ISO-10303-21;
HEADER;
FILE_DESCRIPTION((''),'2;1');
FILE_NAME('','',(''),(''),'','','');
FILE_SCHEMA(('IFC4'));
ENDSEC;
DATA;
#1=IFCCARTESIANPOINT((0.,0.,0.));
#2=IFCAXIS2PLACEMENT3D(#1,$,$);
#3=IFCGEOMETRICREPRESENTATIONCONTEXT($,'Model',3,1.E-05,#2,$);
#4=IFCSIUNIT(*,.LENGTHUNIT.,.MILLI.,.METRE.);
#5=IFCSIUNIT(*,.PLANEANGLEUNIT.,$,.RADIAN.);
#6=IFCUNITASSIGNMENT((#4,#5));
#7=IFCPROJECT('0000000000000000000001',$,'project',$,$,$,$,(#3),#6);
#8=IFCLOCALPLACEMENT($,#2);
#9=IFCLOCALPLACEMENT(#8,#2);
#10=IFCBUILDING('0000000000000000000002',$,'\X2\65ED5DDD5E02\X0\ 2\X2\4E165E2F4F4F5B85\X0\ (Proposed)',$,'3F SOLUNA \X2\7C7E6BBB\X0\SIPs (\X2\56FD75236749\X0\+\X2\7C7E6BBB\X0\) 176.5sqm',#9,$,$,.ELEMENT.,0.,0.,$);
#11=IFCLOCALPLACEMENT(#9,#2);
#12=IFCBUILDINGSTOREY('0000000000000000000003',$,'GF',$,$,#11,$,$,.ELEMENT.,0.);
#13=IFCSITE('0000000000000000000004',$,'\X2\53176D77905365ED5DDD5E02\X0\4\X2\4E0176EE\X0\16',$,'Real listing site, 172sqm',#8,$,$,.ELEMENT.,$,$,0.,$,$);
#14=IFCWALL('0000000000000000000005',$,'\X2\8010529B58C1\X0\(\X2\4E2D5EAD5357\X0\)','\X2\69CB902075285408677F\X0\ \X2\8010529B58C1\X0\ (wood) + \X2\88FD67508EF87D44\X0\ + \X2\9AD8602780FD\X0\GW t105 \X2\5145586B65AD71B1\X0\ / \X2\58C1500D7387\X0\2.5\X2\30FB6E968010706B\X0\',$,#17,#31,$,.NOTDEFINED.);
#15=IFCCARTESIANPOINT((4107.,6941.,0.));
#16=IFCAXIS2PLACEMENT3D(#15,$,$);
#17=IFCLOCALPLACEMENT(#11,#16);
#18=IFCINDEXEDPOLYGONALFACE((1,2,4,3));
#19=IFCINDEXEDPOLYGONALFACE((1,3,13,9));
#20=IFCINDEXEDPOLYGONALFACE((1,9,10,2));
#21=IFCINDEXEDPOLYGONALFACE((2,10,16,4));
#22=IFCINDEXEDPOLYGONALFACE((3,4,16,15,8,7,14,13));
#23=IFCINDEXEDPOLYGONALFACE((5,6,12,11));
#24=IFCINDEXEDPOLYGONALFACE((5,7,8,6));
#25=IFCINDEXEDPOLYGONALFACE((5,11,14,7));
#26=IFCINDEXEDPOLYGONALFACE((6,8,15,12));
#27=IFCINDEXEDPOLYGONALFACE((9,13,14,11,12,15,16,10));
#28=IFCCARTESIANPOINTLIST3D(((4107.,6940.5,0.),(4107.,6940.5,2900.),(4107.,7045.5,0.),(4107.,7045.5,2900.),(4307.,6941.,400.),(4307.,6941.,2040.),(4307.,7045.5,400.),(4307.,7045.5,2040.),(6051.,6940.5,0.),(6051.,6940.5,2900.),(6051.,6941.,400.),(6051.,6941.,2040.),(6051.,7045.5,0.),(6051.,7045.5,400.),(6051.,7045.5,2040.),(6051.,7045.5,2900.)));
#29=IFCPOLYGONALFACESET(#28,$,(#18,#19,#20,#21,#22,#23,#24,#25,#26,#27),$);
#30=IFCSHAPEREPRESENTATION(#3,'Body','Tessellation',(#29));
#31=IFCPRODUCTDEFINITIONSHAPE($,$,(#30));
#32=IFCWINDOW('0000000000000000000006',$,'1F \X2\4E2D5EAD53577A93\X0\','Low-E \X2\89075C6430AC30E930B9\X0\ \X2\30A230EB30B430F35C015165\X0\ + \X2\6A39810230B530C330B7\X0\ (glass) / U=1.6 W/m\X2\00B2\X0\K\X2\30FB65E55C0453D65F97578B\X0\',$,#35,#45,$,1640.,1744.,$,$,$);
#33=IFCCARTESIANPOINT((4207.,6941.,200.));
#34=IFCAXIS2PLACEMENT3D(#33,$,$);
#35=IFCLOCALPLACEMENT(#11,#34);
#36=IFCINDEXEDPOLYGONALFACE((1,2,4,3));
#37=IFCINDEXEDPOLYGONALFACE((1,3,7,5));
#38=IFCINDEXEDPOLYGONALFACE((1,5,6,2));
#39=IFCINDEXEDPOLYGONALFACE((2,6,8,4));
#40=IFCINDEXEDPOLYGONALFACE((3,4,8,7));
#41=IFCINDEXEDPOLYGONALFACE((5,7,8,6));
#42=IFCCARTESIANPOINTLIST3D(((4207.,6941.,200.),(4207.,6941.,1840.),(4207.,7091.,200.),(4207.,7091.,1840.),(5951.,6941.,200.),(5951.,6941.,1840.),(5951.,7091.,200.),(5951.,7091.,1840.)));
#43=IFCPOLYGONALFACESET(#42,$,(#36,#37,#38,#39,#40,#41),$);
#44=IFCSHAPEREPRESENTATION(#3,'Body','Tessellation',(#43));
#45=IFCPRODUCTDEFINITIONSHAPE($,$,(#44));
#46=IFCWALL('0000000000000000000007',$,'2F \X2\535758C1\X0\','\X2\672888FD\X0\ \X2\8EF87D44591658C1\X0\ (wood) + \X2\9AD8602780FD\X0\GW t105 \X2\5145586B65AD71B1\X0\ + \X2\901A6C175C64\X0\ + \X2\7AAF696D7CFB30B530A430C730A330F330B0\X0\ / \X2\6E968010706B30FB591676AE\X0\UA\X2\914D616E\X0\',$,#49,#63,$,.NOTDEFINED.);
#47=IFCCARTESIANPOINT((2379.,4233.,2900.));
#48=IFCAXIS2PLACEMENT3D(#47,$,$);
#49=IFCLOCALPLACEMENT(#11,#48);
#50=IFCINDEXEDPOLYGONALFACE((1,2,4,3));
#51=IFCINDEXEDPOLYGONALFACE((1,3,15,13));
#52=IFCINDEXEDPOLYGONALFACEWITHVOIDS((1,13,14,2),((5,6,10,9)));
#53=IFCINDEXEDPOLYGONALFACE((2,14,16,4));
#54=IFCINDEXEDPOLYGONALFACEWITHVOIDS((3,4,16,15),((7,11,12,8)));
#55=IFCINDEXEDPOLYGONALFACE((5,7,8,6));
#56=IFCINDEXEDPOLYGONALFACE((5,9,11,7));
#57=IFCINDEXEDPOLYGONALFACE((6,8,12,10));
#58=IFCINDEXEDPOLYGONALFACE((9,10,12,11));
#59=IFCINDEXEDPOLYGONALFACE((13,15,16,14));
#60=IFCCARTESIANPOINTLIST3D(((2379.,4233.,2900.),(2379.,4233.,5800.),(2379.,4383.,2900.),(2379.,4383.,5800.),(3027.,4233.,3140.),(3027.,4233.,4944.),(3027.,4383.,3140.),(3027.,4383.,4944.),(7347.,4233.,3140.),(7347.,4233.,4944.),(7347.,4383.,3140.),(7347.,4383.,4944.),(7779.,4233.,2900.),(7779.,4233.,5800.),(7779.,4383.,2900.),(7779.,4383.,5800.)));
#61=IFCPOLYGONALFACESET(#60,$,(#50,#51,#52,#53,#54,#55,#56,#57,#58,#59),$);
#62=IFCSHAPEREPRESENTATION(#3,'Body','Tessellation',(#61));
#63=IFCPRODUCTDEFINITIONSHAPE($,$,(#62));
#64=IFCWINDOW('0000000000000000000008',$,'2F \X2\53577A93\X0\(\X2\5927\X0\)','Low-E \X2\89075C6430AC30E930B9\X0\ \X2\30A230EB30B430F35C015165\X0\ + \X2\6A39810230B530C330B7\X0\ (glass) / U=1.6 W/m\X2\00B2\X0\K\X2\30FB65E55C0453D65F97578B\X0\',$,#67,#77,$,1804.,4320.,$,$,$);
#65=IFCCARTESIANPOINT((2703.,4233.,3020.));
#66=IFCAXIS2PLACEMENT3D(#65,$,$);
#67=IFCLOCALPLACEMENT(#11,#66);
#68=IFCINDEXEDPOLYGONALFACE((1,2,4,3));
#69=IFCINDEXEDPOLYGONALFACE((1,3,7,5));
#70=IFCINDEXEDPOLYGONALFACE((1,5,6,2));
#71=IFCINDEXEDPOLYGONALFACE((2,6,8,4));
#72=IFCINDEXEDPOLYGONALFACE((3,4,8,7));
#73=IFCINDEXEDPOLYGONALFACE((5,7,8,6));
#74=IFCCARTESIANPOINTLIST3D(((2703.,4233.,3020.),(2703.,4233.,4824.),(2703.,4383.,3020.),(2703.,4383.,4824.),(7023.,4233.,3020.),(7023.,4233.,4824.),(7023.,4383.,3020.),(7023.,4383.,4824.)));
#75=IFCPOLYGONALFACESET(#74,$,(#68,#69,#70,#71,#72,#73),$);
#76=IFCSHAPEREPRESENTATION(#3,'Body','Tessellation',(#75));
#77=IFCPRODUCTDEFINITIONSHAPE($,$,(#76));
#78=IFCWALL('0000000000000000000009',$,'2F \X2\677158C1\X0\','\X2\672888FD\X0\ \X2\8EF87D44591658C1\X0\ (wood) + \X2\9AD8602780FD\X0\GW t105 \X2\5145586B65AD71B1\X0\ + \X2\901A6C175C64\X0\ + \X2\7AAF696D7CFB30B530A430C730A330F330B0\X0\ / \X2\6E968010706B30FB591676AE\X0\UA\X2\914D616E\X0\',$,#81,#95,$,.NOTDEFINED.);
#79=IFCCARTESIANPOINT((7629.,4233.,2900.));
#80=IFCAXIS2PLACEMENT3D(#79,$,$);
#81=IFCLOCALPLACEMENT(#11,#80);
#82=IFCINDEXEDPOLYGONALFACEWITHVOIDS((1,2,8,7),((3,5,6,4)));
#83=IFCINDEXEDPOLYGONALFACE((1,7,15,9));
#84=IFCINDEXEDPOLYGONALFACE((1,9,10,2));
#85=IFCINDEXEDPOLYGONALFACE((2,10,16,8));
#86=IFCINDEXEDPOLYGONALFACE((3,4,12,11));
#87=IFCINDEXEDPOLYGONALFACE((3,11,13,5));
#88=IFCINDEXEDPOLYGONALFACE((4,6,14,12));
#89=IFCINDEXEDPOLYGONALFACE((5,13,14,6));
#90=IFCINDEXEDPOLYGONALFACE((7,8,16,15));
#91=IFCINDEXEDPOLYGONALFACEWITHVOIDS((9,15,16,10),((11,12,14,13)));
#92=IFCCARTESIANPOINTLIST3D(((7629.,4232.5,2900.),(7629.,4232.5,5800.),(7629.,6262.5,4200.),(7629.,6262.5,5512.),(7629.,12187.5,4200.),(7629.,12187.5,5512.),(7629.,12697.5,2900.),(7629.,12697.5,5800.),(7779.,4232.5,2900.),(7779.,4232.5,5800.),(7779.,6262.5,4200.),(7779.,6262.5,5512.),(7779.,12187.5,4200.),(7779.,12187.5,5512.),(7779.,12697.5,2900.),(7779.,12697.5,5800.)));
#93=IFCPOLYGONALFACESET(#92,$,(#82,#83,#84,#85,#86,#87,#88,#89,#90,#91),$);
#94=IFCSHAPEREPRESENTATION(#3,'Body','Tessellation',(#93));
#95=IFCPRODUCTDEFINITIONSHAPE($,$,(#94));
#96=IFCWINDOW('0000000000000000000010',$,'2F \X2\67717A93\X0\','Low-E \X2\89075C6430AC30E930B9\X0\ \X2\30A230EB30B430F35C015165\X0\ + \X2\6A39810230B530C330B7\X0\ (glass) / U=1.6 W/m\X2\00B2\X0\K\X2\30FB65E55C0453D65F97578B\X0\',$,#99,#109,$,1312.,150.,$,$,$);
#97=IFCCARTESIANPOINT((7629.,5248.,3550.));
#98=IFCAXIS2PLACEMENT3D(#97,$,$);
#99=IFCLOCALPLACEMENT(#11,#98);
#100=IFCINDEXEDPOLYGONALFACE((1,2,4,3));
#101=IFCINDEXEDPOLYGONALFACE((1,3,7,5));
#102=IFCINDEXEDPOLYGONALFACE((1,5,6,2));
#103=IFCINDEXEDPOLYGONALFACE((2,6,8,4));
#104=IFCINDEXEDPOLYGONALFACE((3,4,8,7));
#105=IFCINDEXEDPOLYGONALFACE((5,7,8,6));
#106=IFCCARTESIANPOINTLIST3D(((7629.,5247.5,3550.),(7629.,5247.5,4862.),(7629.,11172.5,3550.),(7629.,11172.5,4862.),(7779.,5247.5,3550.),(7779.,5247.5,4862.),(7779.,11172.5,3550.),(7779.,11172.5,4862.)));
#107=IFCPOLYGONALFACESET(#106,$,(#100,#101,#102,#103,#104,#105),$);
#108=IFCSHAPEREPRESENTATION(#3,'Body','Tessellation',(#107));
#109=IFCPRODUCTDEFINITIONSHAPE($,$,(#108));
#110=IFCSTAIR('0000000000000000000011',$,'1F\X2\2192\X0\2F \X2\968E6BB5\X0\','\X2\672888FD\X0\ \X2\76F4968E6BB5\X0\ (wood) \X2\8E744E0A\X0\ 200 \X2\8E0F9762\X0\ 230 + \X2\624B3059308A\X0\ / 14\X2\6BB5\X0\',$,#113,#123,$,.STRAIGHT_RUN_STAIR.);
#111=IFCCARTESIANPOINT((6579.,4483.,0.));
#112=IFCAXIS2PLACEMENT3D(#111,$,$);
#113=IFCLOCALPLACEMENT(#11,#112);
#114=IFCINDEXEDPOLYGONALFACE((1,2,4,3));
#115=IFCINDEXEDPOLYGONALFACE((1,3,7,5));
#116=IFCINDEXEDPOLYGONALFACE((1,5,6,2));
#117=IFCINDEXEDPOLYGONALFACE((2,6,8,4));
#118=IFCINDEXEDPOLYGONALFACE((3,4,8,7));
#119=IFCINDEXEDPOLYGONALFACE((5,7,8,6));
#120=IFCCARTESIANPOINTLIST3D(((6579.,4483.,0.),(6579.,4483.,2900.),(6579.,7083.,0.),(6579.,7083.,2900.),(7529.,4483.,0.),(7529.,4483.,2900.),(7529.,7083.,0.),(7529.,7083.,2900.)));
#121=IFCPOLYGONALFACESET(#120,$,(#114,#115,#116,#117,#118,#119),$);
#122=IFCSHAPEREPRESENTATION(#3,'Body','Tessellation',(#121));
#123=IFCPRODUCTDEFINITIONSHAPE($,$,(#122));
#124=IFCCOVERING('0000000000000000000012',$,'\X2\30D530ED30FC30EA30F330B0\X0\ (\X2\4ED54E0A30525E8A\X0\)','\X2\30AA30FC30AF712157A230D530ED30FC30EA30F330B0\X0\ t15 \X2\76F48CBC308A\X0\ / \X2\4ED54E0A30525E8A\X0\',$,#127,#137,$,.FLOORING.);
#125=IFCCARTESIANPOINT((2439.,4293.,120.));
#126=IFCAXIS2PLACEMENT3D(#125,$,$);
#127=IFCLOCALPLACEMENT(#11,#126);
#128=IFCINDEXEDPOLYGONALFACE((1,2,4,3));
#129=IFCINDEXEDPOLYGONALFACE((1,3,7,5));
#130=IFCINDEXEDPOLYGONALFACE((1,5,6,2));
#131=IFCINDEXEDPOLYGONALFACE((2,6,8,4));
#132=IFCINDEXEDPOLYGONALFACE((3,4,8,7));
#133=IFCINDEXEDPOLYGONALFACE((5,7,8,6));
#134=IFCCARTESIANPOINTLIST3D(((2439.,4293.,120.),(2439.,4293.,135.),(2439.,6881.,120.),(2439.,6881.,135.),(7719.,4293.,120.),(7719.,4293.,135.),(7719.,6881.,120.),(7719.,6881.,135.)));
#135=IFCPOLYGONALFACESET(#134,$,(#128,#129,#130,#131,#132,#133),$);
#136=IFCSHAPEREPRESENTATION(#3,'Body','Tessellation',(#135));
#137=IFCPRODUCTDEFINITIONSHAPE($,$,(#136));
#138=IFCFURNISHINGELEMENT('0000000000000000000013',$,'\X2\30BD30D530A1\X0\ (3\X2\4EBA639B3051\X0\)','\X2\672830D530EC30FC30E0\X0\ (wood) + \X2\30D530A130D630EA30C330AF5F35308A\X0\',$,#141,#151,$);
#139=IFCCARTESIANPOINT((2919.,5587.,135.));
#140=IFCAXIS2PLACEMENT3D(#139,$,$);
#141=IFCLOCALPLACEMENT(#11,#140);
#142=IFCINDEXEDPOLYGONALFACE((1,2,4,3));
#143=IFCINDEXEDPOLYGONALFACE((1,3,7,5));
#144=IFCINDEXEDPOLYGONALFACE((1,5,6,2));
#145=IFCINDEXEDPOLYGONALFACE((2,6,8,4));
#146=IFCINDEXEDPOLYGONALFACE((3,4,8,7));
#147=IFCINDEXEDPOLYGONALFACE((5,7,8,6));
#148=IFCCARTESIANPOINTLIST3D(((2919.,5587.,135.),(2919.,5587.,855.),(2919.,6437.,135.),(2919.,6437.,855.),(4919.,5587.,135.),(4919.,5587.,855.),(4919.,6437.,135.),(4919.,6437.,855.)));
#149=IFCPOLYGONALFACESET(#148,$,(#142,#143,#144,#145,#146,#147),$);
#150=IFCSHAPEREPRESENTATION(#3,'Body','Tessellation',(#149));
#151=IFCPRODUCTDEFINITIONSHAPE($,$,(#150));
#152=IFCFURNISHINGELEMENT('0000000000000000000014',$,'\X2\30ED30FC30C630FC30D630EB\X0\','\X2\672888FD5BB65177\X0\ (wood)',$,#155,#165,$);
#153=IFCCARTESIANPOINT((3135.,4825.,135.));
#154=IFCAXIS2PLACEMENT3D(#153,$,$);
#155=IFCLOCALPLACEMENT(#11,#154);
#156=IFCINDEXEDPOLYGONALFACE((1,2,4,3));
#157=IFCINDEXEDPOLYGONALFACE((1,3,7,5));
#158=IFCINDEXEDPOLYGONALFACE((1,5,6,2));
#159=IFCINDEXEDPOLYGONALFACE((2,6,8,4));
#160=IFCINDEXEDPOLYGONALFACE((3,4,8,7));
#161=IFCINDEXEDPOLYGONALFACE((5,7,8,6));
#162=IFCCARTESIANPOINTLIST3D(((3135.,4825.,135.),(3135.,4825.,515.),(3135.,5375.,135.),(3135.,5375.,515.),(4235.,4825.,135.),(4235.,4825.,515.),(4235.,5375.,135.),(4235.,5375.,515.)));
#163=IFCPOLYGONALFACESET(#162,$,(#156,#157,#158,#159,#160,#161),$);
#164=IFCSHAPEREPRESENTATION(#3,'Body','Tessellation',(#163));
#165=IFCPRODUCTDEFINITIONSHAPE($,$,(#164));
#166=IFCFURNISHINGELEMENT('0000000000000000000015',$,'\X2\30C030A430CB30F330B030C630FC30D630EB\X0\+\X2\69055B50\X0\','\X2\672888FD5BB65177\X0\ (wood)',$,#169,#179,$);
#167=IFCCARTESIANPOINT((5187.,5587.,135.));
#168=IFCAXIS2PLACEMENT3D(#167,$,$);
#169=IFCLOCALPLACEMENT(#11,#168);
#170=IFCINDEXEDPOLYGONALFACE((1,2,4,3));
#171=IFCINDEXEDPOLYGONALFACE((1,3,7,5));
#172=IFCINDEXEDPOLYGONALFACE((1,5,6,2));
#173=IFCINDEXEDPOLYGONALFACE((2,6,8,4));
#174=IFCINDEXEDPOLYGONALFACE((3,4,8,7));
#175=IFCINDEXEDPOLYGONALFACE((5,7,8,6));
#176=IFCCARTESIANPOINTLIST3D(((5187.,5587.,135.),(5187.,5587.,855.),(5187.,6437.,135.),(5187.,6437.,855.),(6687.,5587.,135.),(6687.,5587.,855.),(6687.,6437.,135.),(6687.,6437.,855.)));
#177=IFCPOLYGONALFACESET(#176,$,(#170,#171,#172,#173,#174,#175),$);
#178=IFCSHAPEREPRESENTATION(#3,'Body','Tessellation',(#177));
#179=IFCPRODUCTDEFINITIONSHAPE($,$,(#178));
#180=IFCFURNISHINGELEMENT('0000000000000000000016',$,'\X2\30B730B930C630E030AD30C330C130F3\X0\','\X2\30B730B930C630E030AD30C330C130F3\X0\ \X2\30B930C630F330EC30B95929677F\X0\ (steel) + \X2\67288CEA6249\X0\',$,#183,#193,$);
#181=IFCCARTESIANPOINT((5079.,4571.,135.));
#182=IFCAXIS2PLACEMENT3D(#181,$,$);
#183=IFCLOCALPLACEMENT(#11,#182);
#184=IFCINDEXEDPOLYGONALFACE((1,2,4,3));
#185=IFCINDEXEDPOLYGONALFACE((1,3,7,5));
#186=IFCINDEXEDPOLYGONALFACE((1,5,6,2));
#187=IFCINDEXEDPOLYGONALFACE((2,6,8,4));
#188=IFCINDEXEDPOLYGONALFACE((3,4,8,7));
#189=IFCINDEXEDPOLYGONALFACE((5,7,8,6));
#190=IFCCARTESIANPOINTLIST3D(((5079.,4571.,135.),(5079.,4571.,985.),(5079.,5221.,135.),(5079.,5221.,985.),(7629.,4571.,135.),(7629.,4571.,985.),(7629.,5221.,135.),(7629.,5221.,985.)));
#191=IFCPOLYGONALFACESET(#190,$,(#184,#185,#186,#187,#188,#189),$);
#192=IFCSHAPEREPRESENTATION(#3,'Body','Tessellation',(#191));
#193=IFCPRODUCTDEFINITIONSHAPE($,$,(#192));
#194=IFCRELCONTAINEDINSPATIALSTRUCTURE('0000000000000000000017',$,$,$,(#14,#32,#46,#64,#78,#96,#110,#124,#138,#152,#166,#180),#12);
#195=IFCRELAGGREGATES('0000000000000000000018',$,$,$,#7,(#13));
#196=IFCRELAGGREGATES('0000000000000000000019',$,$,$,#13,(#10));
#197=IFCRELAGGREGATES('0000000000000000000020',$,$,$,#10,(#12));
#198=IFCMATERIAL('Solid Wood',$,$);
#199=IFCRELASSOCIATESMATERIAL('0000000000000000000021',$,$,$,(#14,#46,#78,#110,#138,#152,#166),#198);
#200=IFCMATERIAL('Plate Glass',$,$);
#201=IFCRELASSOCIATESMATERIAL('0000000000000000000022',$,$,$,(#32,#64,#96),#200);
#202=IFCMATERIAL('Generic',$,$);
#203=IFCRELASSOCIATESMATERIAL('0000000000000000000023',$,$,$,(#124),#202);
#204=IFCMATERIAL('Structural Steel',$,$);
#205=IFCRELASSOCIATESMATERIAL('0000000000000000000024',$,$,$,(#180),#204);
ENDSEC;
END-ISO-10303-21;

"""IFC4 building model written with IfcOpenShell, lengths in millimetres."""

from ifc_helpers import new_model, si_unit, frame, frame_2d, origin, place, context, project, spatial, rectangle, extrude, material, element, fill, save


model = new_model("IFC4")

# Units and contexts
model_context = context("Model", 3, precision=1e-05, world=origin())
ifc_project = project(units=[si_unit("LENGTHUNIT", "METRE", prefix="MILLI"), si_unit("PLANEANGLEUNIT", "RADIAN")], contexts=[model_context])

# Site, building, storey
site_placement = place(None, origin())
site = spatial("IfcSite", under=ifc_project, at=site_placement, Name="北海道旭川市4丁目16", ObjectType="Real listing site, 172sqm", CompositionType="ELEMENT", RefElevation=0.0)
building_placement = place(site_placement, origin())
building = spatial("IfcBuilding", under=site, at=building_placement, Name="旭川市 2世帯住宅 (Proposed)", ObjectType="3F SOLUNA 籾殻SIPs (国産杉+籾殻) 176.5sqm", CompositionType="ELEMENT", ElevationOfRefHeight=0.0, ElevationOfTerrain=0.0)
storey_placement = place(building_placement, origin())
storey = spatial("IfcBuildingStorey", under=building, at=storey_placement, Name="GF", CompositionType="ELEMENT", Elevation=0.0)

# Shared definitions
ifc_material_1 = material(Name="Solid Wood")
ifc_material_2 = material(Name="Generic")

# Shared definitions
ifc_material_3 = material(Name="Plate Glass")

# Wall, opening, window
wall_1_placement = place(storey_placement, frame((4107.0, 6941.0, 0.0)))
wall_1 = element("IfcWall", 1, at=wall_1_placement, inside=storey, material=ifc_material_1, Name="耐力壁(中庭南)", Description="構造用合板 耐力壁 (wood) + 製材軸組 + 高性能GW t105 充填断熱 / 壁倍率2.5・準耐火", PredefinedType="NOTDEFINED", context=model_context, shape_type="SweptSolid", body=[
    extrude(rectangle(XDim=1944.0, YDim=105.0, at=frame_2d((972.0, 52.0))), frame((4107.0, 6941.0, 0.0)), (0.0, 0.0, 1.0), 2900.0),
])
opening_1_placement = place(storey_placement, frame((4207.0, 6941.0, 200.0)))
opening_1 = element("IfcOpeningElement", 2, at=opening_1_placement, cuts=wall_1, PredefinedType="NOTDEFINED", context=model_context, shape_type="SweptSolid", body=[
    extrude(rectangle(XDim=1744.0, YDim=150.0, at=frame_2d((872.0, 75.0))), frame((4207.0, 6941.0, 200.0)), (0.0, 0.0, 1.0), 1640.0),
])
window_1_placement = place(storey_placement, frame((4207.0, 6941.0, 200.0)))
window_1 = element("IfcWindow", 3, at=window_1_placement, inside=storey, material=ifc_material_3, Name="1F 中庭南窓", Description="Low-E 複層ガラス アルゴン封入 + 樹脂サッシ (glass) / U=1.6 W/m²K・日射取得型", OverallHeight=1640.0, OverallWidth=1744.0, context=model_context, shape_type="SweptSolid", body=[
    extrude(rectangle(XDim=1744.0, YDim=150.0, at=frame_2d((872.0, 75.0))), frame((4207.0, 6941.0, 200.0)), (0.0, 0.0, 1.0), 1640.0),
])
fill(opening_1, window_1)

# Walls, openings, windows
wall_2_placement = place(storey_placement, frame((2379.0, 4233.0, 2900.0)))
wall_2 = element("IfcWall", 4, at=wall_2_placement, inside=storey, material=ifc_material_1, Name="2F 南壁", Description="木製 軸組外壁 (wood) + 高性能GW t105 充填断熱 + 通気層 + 窯業系サイディング / 準耐火・外皮UA配慮", PredefinedType="NOTDEFINED", context=model_context, shape_type="SweptSolid", body=[
    extrude(rectangle(XDim=5400.0, YDim=150.0, at=frame_2d((2700.0, 75.0))), frame((2379.0, 4233.0, 2900.0)), (0.0, 0.0, 1.0), 2900.0),
])
opening_2_placement = place(storey_placement, frame((2703.0, 4233.0, 3020.0)))
opening_2 = element("IfcOpeningElement", 5, at=opening_2_placement, cuts=wall_2, PredefinedType="NOTDEFINED", context=model_context, shape_type="SweptSolid", body=[
    extrude(rectangle(XDim=4320.0, YDim=150.0, at=frame_2d((2160.0, 75.0))), frame((2703.0, 4233.0, 3020.0)), (0.0, 0.0, 1.0), 1804.0),
])
window_2_placement = place(storey_placement, frame((2703.0, 4233.0, 3020.0)))
window_2 = element("IfcWindow", 6, at=window_2_placement, inside=storey, material=ifc_material_3, Name="2F 南窓(大)", Description="Low-E 複層ガラス アルゴン封入 + 樹脂サッシ (glass) / U=1.6 W/m²K・日射取得型", OverallHeight=1804.0, OverallWidth=4320.0, context=model_context, shape_type="SweptSolid", body=[
    extrude(rectangle(XDim=4320.0, YDim=150.0, at=frame_2d((2160.0, 75.0))), frame((2703.0, 4233.0, 3020.0)), (0.0, 0.0, 1.0), 1804.0),
])
fill(opening_2, window_2)
wall_3_placement = place(storey_placement, frame((7629.0, 4233.0, 2900.0)))
wall_3 = element("IfcWall", 7, at=wall_3_placement, inside=storey, material=ifc_material_1, Name="2F 東壁", Description="木製 軸組外壁 (wood) + 高性能GW t105 充填断熱 + 通気層 + 窯業系サイディング / 準耐火・外皮UA配慮", PredefinedType="NOTDEFINED", context=model_context, shape_type="SweptSolid", body=[
    extrude(rectangle(XDim=150.0, YDim=8465.0, at=frame_2d((75.0, 4232.0))), frame((7629.0, 4233.0, 2900.0)), (0.0, 0.0, 1.0), 2900.0),
])
opening_3_placement = place(storey_placement, frame((7629.0, 5248.0, 3550.0)))
opening_3 = element("IfcOpeningElement", 8, at=opening_3_placement, cuts=wall_3, PredefinedType="NOTDEFINED", context=model_context, shape_type="SweptSolid", body=[
    extrude(rectangle(XDim=150.0, YDim=5925.0, at=frame_2d((75.0, 2962.0))), frame((7629.0, 5248.0, 3550.0)), (0.0, 0.0, 1.0), 1312.0),
])
window_3_placement = place(storey_placement, frame((7629.0, 5248.0, 3550.0)))
window_3 = element("IfcWindow", 9, at=window_3_placement, inside=storey, material=ifc_material_3, Name="2F 東窓", Description="Low-E 複層ガラス アルゴン封入 + 樹脂サッシ (glass) / U=1.6 W/m²K・日射取得型", OverallHeight=1312.0, OverallWidth=150.0, context=model_context, shape_type="SweptSolid", body=[
    extrude(rectangle(XDim=150.0, YDim=5925.0, at=frame_2d((75.0, 2962.0))), frame((7629.0, 5248.0, 3550.0)), (0.0, 0.0, 1.0), 1312.0),
])
fill(opening_3, window_3)

# Stair
stair_placement = place(storey_placement, frame((6579.0, 4483.0, 0.0)))
element("IfcStair", 10, at=stair_placement, inside=storey, material=ifc_material_1, Name="1F→2F 階段", Description="木製 直階段 (wood) 蹴上 200 踏面 230 + 手すり / 14段", PredefinedType="STRAIGHT_RUN_STAIR", context=model_context, shape_type="SweptSolid", body=[
    extrude(rectangle(XDim=950.0, YDim=2600.0, at=frame_2d((475.0, 1300.0))), frame((6579.0, 4483.0, 0.0)), (0.0, 0.0, 1.0), 2900.0),
])

# Covering
covering_placement = place(storey_placement, frame((2439.0, 4293.0, 120.0)))
element("IfcCovering", 11, at=covering_placement, inside=storey, material=ifc_material_2, Name="フローリング (仕上げ床)", Description="オーク無垢フローリング t15 直貼り / 仕上げ床", PredefinedType="FLOORING", context=model_context, shape_type="SweptSolid", body=[
    extrude(rectangle(XDim=5280.0, YDim=2588.0, at=frame_2d((2640.0, 1294.0))), frame((2439.0, 4293.0, 120.0)), (0.0, 0.0, 1.0), 15.0),
])

# Furnishing elements
furnishing_1_placement = place(storey_placement, frame((2919.0, 5587.0, 135.0)))
element("IfcFurnishingElement", 12, at=furnishing_1_placement, inside=storey, material=ifc_material_1, Name="ソファ (3人掛け)", Description="木フレーム (wood) + ファブリック張り", context=model_context, shape_type="SweptSolid", body=[
    extrude(rectangle(XDim=2000.0, YDim=850.0, at=frame_2d((1000.0, 425.0))), frame((2919.0, 5587.0, 135.0)), (0.0, 0.0, 1.0), 720.0),
])
furnishing_2_placement = place(storey_placement, frame((3135.0, 4825.0, 135.0)))
element("IfcFurnishingElement", 13, at=furnishing_2_placement, inside=storey, material=ifc_material_1, Name="ローテーブル", Description="木製家具 (wood)", context=model_context, shape_type="SweptSolid", body=[
    extrude(rectangle(XDim=1100.0, YDim=550.0, at=frame_2d((550.0, 275.0))), frame((3135.0, 4825.0, 135.0)), (0.0, 0.0, 1.0), 380.0),
])
furnishing_3_placement = place(storey_placement, frame((5187.0, 5587.0, 135.0)))
element("IfcFurnishingElement", 14, at=furnishing_3_placement, inside=storey, material=ifc_material_1, Name="ダイニングテーブル+椅子", Description="木製家具 (wood)", context=model_context, shape_type="SweptSolid", body=[
    extrude(rectangle(XDim=1500.0, YDim=850.0, at=frame_2d((750.0, 425.0))), frame((5187.0, 5587.0, 135.0)), (0.0, 0.0, 1.0), 720.0),
])
ifc_material_4 = material(Name="Structural Steel")
furnishing_4_placement = place(storey_placement, frame((5079.0, 4571.0, 135.0)))
element("IfcFurnishingElement", 15, at=furnishing_4_placement, inside=storey, material=ifc_material_4, Name="システムキッチン", Description="システムキッチン ステンレス天板 (steel) + 木質扉", context=model_context, shape_type="SweptSolid", body=[
    extrude(rectangle(XDim=2550.0, YDim=650.0, at=frame_2d((1275.0, 325.0))), frame((5079.0, 4571.0, 135.0)), (0.0, 0.0, 1.0), 850.0),
])

save(model, "model.ifc")
